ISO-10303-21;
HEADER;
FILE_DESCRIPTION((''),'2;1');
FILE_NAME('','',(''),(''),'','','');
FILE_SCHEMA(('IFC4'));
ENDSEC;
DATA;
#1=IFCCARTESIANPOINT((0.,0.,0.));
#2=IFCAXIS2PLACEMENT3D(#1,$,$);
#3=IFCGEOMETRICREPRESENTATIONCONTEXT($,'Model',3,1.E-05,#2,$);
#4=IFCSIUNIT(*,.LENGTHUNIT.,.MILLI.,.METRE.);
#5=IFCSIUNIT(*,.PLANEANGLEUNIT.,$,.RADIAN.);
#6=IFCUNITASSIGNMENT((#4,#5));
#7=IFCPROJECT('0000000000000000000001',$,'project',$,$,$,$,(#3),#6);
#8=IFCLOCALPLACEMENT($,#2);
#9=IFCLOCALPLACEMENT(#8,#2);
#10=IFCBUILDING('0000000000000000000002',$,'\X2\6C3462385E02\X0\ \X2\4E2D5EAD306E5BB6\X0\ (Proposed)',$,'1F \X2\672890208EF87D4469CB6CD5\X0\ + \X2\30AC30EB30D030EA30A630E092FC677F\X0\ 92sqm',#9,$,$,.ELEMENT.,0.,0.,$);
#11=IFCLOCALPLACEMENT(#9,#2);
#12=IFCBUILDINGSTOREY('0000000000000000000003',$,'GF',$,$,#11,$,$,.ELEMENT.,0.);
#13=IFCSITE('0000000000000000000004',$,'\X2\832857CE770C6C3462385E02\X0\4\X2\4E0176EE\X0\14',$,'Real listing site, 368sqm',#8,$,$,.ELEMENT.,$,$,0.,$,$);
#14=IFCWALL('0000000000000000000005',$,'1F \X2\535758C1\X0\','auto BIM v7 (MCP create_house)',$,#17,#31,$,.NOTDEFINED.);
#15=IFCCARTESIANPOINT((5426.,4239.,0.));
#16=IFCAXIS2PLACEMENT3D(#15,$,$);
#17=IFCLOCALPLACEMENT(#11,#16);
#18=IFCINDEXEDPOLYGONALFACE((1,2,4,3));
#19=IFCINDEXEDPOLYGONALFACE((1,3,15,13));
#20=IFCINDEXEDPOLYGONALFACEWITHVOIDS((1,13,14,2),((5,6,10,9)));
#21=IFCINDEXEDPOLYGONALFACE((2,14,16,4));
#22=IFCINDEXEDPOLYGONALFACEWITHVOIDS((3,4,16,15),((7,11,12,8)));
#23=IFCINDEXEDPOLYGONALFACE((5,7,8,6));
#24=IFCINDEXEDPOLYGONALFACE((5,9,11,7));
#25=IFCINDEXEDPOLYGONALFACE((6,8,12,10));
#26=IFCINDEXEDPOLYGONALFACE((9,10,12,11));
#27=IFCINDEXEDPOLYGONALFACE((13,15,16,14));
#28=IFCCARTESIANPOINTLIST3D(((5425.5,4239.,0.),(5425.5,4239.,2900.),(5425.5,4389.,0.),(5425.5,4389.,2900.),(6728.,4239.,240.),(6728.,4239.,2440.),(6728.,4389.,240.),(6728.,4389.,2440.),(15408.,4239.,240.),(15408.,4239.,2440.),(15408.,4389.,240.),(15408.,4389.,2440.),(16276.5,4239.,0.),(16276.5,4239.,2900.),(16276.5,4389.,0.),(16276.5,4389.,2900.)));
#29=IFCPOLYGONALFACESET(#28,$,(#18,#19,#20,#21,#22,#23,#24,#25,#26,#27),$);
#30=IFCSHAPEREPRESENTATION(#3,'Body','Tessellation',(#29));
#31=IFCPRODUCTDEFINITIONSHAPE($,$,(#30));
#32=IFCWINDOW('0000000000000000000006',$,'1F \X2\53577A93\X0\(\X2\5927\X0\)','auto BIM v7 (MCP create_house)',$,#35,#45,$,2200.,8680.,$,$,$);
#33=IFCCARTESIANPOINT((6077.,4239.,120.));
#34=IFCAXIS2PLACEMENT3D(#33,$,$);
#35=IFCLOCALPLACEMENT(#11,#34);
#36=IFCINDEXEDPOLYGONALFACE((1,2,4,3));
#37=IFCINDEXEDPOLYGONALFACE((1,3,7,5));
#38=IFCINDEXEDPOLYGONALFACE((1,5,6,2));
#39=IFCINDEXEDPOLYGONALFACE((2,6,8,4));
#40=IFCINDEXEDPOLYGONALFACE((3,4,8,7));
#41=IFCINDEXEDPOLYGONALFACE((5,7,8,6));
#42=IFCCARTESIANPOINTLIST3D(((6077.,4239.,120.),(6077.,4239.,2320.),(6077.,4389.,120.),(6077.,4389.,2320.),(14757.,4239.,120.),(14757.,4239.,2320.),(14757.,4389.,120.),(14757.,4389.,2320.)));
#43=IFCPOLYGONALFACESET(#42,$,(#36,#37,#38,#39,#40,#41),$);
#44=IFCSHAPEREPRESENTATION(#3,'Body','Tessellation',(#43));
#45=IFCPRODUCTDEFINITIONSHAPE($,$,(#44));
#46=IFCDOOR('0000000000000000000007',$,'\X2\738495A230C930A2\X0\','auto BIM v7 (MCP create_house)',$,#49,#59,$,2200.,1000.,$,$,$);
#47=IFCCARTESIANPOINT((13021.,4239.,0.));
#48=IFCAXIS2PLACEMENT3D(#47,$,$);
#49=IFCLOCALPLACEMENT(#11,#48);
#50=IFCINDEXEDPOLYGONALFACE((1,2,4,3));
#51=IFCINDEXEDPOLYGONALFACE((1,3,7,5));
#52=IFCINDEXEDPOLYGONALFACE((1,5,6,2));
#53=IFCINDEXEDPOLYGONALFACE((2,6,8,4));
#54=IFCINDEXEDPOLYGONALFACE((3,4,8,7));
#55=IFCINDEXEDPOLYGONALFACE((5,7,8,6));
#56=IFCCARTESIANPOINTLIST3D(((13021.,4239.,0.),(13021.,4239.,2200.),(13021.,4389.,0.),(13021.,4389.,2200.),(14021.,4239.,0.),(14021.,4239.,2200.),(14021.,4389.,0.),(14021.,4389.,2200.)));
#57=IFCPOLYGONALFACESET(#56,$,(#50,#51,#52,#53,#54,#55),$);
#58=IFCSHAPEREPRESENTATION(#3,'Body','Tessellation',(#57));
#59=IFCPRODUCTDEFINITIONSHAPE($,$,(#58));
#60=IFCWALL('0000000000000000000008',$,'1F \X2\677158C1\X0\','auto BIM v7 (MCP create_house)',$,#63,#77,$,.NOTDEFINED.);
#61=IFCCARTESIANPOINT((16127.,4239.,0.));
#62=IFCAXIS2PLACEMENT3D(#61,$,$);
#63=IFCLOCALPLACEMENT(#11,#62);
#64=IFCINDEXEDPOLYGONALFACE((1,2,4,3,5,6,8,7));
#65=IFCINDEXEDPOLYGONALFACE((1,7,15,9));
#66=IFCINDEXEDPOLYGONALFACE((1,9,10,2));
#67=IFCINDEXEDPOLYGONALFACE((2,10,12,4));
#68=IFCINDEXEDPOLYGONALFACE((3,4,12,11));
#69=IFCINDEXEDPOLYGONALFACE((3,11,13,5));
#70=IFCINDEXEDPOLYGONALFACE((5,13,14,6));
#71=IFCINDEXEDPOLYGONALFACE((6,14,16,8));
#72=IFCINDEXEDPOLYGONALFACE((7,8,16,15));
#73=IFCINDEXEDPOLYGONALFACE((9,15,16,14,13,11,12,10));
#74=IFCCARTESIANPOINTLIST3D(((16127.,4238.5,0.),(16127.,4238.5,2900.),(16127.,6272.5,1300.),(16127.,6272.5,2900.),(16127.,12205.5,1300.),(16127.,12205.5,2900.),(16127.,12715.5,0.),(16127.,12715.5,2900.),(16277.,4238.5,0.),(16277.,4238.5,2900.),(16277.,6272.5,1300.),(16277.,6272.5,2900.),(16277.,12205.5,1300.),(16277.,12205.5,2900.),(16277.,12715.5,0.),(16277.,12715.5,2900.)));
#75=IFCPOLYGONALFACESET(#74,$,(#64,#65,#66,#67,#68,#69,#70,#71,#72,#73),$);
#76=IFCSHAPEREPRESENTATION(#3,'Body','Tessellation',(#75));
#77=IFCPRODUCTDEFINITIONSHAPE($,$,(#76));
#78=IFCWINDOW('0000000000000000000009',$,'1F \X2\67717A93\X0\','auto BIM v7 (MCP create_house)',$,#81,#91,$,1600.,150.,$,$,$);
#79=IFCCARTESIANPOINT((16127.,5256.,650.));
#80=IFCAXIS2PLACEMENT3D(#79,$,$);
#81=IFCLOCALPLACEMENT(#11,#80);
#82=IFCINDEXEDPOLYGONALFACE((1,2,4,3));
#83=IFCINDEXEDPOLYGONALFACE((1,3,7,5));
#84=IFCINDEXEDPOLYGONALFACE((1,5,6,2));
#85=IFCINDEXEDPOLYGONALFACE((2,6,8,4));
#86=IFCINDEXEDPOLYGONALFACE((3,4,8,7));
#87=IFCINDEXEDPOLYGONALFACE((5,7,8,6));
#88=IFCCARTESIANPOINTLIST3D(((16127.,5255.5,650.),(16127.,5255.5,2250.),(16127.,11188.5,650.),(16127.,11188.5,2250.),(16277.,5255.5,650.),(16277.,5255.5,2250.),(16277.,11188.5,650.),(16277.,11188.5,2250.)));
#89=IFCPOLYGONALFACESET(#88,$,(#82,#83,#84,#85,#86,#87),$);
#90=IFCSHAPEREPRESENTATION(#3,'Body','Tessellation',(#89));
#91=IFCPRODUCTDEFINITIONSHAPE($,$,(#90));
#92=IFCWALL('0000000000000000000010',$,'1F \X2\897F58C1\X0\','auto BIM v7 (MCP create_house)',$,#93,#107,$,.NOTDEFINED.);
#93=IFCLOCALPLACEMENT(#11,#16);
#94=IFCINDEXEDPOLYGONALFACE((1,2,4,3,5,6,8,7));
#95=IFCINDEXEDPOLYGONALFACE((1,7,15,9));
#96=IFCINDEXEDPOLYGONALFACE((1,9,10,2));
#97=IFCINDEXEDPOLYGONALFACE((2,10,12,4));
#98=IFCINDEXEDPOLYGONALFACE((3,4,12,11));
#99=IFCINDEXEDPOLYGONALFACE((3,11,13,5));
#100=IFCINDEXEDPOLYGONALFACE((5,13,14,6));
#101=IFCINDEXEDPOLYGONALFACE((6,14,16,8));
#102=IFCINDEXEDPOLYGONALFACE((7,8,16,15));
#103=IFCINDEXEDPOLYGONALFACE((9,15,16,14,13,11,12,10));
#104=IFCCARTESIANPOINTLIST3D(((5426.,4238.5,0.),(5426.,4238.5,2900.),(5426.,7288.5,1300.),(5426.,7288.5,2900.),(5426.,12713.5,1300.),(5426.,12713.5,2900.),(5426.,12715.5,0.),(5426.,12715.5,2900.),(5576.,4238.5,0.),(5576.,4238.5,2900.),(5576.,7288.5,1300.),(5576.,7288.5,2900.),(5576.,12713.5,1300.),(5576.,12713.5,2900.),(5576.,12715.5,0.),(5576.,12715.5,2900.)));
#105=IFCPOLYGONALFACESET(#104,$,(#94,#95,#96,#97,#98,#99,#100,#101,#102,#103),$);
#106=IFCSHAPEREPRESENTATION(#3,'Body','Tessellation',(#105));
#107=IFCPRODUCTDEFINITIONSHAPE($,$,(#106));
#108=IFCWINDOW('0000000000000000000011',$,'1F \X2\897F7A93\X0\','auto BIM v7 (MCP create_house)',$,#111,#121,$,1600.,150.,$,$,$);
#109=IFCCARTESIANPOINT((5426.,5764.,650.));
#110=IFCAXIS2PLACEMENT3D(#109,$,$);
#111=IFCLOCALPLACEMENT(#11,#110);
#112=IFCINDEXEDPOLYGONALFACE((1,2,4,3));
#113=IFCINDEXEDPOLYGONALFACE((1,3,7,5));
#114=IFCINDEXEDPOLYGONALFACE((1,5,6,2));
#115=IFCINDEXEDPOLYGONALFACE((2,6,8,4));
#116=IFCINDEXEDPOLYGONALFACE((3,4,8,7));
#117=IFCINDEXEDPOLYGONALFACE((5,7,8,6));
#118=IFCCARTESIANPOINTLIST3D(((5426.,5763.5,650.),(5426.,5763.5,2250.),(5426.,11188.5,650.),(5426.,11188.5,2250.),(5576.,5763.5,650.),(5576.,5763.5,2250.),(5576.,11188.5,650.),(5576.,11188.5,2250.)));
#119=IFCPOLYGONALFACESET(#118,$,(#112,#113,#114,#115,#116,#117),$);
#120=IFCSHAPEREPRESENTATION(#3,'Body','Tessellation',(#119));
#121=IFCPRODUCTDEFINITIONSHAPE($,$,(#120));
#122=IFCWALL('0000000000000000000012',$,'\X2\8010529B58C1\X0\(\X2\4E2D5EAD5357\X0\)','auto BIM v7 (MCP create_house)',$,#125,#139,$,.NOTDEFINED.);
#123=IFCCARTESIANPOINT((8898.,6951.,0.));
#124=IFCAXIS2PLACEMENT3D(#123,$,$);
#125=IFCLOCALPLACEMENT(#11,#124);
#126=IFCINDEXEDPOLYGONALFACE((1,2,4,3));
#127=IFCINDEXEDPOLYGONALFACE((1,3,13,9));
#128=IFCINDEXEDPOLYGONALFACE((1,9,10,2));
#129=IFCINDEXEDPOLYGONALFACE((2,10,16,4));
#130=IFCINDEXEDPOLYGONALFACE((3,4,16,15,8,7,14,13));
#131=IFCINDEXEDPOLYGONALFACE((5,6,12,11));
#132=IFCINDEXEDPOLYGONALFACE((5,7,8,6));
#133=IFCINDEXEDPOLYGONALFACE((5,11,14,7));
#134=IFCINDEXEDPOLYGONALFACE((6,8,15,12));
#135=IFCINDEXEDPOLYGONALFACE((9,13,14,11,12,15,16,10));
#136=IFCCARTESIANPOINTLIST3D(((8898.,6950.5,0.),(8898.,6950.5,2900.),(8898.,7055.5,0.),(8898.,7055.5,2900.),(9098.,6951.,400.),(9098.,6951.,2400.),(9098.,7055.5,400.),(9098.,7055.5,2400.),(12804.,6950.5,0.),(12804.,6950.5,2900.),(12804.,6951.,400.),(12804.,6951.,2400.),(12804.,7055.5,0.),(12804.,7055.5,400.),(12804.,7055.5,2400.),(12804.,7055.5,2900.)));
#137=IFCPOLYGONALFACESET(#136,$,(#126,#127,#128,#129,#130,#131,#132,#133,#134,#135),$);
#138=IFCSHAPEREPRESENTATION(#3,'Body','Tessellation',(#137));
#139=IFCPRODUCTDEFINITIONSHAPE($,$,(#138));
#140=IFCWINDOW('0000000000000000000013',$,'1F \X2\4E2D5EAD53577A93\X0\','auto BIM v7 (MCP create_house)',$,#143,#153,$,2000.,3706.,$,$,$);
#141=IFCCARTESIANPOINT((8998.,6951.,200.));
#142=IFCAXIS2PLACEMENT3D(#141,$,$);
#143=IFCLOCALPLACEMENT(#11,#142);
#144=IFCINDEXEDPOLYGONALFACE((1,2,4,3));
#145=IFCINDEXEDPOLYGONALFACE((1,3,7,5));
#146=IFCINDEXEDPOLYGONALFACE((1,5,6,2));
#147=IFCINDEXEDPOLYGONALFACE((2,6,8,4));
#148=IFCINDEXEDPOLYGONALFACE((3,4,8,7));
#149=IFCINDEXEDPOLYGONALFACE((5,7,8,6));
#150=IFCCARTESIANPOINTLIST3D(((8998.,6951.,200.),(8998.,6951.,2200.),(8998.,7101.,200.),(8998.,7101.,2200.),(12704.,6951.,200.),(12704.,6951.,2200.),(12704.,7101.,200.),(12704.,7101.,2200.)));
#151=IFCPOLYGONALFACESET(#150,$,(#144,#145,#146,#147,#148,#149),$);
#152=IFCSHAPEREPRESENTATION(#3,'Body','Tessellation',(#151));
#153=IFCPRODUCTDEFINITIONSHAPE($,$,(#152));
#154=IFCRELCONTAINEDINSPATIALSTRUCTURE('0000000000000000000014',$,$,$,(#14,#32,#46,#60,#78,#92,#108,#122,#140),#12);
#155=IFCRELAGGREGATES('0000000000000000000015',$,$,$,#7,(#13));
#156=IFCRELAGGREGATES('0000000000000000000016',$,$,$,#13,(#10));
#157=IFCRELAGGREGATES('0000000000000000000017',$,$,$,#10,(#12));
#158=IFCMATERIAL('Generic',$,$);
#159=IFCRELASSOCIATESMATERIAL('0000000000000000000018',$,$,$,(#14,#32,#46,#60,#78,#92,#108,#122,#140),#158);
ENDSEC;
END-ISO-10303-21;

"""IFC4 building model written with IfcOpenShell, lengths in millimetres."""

from ifc_helpers import new_model, si_unit, frame, frame_2d, origin, place, context, project, spatial, rectangle, extrude, material, element, fill, save


model = new_model("IFC4")

# Units and contexts
model_context = context("Model", 3, precision=1e-05, world=origin())
ifc_project = project(units=[si_unit("LENGTHUNIT", "METRE", prefix="MILLI"), si_unit("PLANEANGLEUNIT", "RADIAN")], contexts=[model_context])

# Site, building, storey
site_placement = place(None, origin())
site = spatial("IfcSite", under=ifc_project, at=site_placement, Name="茨城県水戸市4丁目14", ObjectType="Real listing site, 368sqm", CompositionType="ELEMENT", RefElevation=0.0)
building_placement = place(site_placement, origin())
building = spatial("IfcBuilding", under=site, at=building_placement, Name="水戸市 中庭の家 (Proposed)", ObjectType="1F 木造軸組構法 + ガルバリウム鋼板 92sqm", CompositionType="ELEMENT", ElevationOfRefHeight=0.0, ElevationOfTerrain=0.0)
storey_placement = place(building_placement, origin())
storey = spatial("IfcBuildingStorey", under=building, at=storey_placement, Name="GF", CompositionType="ELEMENT", Elevation=0.0)

# Shared definitions
ifc_material = material(Name="Generic")

# Wall, openings, window, door
wall_1_placement = place(storey_placement, frame((5426.0, 4239.0, 0.0)))
wall_1 = element("IfcWall", 1, at=wall_1_placement, inside=storey, material=ifc_material, Name="1F 南壁", Description="auto BIM v7 (MCP create_house)", PredefinedType="NOTDEFINED", context=model_context, shape_type="SweptSolid", body=[
    extrude(rectangle(XDim=10851.0, YDim=150.0, at=frame_2d((5425.0, 75.0))), frame((5426.0, 4239.0, 0.0)), (0.0, 0.0, 1.0), 2900.0),
])
opening_1_placement = place(storey_placement, frame((6077.0, 4239.0, 120.0)))
opening_1 = element("IfcOpeningElement", 2, at=opening_1_placement, cuts=wall_1, PredefinedType="NOTDEFINED", context=model_context, shape_type="SweptSolid", body=[
    extrude(rectangle(XDim=8680.0, YDim=150.0, at=frame_2d((4340.0, 75.0))), frame((6077.0, 4239.0, 120.0)), (0.0, 0.0, 1.0), 2200.0),
])
opening_2_placement = place(storey_placement, frame((13021.0, 4239.0, 0.0)))
opening_2 = element("IfcOpeningElement", 3, at=opening_2_placement, cuts=wall_1, PredefinedType="NOTDEFINED", context=model_context, shape_type="SweptSolid", body=[
    extrude(rectangle(XDim=1000.0, YDim=150.0, at=frame_2d((500.0, 75.0))), frame((13021.0, 4239.0, 0.0)), (0.0, 0.0, 1.0), 2200.0),
])
window_1_placement = place(storey_placement, frame((6077.0, 4239.0, 120.0)))
window_1 = element("IfcWindow", 4, at=window_1_placement, inside=storey, material=ifc_material, Name="1F 南窓(大)", Description="auto BIM v7 (MCP create_house)", OverallHeight=2200.0, OverallWidth=8680.0, context=model_context, shape_type="SweptSolid", body=[
    extrude(rectangle(XDim=8680.0, YDim=150.0, at=frame_2d((4340.0, 75.0))), frame((6077.0, 4239.0, 120.0)), (0.0, 0.0, 1.0), 2200.0),
])
fill(opening_1, window_1)
door_placement = place(storey_placement, frame((13021.0, 4239.0, 0.0)))
door = element("IfcDoor", 5, at=door_placement, inside=storey, material=ifc_material, Name="玄関ドア", Description="auto BIM v7 (MCP create_house)", OverallHeight=2200.0, OverallWidth=1000.0, context=model_context, shape_type="SweptSolid", body=[
    extrude(rectangle(XDim=1000.0, YDim=150.0, at=frame_2d((500.0, 75.0))), frame((13021.0, 4239.0, 0.0)), (0.0, 0.0, 1.0), 2200.0),
])
fill(opening_2, door)

# Walls, openings, windows
wall_2_placement = place(storey_placement, frame((16127.0, 4239.0, 0.0)))
wall_2 = element("IfcWall", 6, at=wall_2_placement, inside=storey, material=ifc_material, Name="1F 東壁", Description="auto BIM v7 (MCP create_house)", PredefinedType="NOTDEFINED", context=model_context, shape_type="SweptSolid", body=[
    extrude(rectangle(XDim=150.0, YDim=8477.0, at=frame_2d((75.0, 4238.0))), frame((16127.0, 4239.0, 0.0)), (0.0, 0.0, 1.0), 2900.0),
])
opening_3_placement = place(storey_placement, frame((16127.0, 5256.0, 650.0)))
opening_3 = element("IfcOpeningElement", 7, at=opening_3_placement, cuts=wall_2, PredefinedType="NOTDEFINED", context=model_context, shape_type="SweptSolid", body=[
    extrude(rectangle(XDim=150.0, YDim=5933.0, at=frame_2d((75.0, 2966.0))), frame((16127.0, 5256.0, 650.0)), (0.0, 0.0, 1.0), 1600.0),
])
window_2_placement = place(storey_placement, frame((16127.0, 5256.0, 650.0)))
window_2 = element("IfcWindow", 8, at=window_2_placement, inside=storey, material=ifc_material, Name="1F 東窓", Description="auto BIM v7 (MCP create_house)", OverallHeight=1600.0, OverallWidth=150.0, context=model_context, shape_type="SweptSolid", body=[
    extrude(rectangle(XDim=150.0, YDim=5933.0, at=frame_2d((75.0, 2966.0))), frame((16127.0, 5256.0, 650.0)), (0.0, 0.0, 1.0), 1600.0),
])
fill(opening_3, window_2)
wall_3_placement = place(storey_placement, frame((5426.0, 4239.0, 0.0)))
wall_3 = element("IfcWall", 9, at=wall_3_placement, inside=storey, material=ifc_material, Name="1F 西壁", Description="auto BIM v7 (MCP create_house)", PredefinedType="NOTDEFINED", context=model_context, shape_type="SweptSolid", body=[
    extrude(rectangle(XDim=150.0, YDim=8477.0, at=frame_2d((75.0, 4238.0))), frame((5426.0, 4239.0, 0.0)), (0.0, 0.0, 1.0), 2900.0),
])
opening_4_placement = place(storey_placement, frame((5426.0, 5764.0, 650.0)))
opening_4 = element("IfcOpeningElement", 10, at=opening_4_placement, cuts=wall_3, PredefinedType="NOTDEFINED", context=model_context, shape_type="SweptSolid", body=[
    extrude(rectangle(XDim=150.0, YDim=5425.0, at=frame_2d((75.0, 2712.0))), frame((5426.0, 5764.0, 650.0)), (0.0, 0.0, 1.0), 1600.0),
])
window_3_placement = place(storey_placement, frame((5426.0, 5764.0, 650.0)))
window_3 = element("IfcWindow", 11, at=window_3_placement, inside=storey, material=ifc_material, Name="1F 西窓", Description="auto BIM v7 (MCP create_house)", OverallHeight=1600.0, OverallWidth=150.0, context=model_context, shape_type="SweptSolid", body=[
    extrude(rectangle(XDim=150.0, YDim=5425.0, at=frame_2d((75.0, 2712.0))), frame((5426.0, 5764.0, 650.0)), (0.0, 0.0, 1.0), 1600.0),
])
fill(opening_4, window_3)
wall_4_placement = place(storey_placement, frame((8898.0, 6951.0, 0.0)))
wall_4 = element("IfcWall", 12, at=wall_4_placement, inside=storey, material=ifc_material, Name="耐力壁(中庭南)", Description="auto BIM v7 (MCP create_house)", PredefinedType="NOTDEFINED", context=model_context, shape_type="SweptSolid", body=[
    extrude(rectangle(XDim=3906.0, YDim=105.0, at=frame_2d((1953.0, 52.0))), frame((8898.0, 6951.0, 0.0)), (0.0, 0.0, 1.0), 2900.0),
])
opening_5_placement = place(storey_placement, frame((8998.0, 6951.0, 200.0)))
opening_5 = element("IfcOpeningElement", 13, at=opening_5_placement, cuts=wall_4, PredefinedType="NOTDEFINED", context=model_context, shape_type="SweptSolid", body=[
    extrude(rectangle(XDim=3706.0, YDim=150.0, at=frame_2d((1853.0, 75.0))), frame((8998.0, 6951.0, 200.0)), (0.0, 0.0, 1.0), 2000.0),
])
window_4_placement = place(storey_placement, frame((8998.0, 6951.0, 200.0)))
window_4 = element("IfcWindow", 14, at=window_4_placement, inside=storey, material=ifc_material, Name="1F 中庭南窓", Description="auto BIM v7 (MCP create_house)", OverallHeight=2000.0, OverallWidth=3706.0, context=model_context, shape_type="SweptSolid", body=[
    extrude(rectangle(XDim=3706.0, YDim=150.0, at=frame_2d((1853.0, 75.0))), frame((8998.0, 6951.0, 200.0)), (0.0, 0.0, 1.0), 2000.0),
])
fill(opening_5, window_4)

save(model, "model.ifc")
